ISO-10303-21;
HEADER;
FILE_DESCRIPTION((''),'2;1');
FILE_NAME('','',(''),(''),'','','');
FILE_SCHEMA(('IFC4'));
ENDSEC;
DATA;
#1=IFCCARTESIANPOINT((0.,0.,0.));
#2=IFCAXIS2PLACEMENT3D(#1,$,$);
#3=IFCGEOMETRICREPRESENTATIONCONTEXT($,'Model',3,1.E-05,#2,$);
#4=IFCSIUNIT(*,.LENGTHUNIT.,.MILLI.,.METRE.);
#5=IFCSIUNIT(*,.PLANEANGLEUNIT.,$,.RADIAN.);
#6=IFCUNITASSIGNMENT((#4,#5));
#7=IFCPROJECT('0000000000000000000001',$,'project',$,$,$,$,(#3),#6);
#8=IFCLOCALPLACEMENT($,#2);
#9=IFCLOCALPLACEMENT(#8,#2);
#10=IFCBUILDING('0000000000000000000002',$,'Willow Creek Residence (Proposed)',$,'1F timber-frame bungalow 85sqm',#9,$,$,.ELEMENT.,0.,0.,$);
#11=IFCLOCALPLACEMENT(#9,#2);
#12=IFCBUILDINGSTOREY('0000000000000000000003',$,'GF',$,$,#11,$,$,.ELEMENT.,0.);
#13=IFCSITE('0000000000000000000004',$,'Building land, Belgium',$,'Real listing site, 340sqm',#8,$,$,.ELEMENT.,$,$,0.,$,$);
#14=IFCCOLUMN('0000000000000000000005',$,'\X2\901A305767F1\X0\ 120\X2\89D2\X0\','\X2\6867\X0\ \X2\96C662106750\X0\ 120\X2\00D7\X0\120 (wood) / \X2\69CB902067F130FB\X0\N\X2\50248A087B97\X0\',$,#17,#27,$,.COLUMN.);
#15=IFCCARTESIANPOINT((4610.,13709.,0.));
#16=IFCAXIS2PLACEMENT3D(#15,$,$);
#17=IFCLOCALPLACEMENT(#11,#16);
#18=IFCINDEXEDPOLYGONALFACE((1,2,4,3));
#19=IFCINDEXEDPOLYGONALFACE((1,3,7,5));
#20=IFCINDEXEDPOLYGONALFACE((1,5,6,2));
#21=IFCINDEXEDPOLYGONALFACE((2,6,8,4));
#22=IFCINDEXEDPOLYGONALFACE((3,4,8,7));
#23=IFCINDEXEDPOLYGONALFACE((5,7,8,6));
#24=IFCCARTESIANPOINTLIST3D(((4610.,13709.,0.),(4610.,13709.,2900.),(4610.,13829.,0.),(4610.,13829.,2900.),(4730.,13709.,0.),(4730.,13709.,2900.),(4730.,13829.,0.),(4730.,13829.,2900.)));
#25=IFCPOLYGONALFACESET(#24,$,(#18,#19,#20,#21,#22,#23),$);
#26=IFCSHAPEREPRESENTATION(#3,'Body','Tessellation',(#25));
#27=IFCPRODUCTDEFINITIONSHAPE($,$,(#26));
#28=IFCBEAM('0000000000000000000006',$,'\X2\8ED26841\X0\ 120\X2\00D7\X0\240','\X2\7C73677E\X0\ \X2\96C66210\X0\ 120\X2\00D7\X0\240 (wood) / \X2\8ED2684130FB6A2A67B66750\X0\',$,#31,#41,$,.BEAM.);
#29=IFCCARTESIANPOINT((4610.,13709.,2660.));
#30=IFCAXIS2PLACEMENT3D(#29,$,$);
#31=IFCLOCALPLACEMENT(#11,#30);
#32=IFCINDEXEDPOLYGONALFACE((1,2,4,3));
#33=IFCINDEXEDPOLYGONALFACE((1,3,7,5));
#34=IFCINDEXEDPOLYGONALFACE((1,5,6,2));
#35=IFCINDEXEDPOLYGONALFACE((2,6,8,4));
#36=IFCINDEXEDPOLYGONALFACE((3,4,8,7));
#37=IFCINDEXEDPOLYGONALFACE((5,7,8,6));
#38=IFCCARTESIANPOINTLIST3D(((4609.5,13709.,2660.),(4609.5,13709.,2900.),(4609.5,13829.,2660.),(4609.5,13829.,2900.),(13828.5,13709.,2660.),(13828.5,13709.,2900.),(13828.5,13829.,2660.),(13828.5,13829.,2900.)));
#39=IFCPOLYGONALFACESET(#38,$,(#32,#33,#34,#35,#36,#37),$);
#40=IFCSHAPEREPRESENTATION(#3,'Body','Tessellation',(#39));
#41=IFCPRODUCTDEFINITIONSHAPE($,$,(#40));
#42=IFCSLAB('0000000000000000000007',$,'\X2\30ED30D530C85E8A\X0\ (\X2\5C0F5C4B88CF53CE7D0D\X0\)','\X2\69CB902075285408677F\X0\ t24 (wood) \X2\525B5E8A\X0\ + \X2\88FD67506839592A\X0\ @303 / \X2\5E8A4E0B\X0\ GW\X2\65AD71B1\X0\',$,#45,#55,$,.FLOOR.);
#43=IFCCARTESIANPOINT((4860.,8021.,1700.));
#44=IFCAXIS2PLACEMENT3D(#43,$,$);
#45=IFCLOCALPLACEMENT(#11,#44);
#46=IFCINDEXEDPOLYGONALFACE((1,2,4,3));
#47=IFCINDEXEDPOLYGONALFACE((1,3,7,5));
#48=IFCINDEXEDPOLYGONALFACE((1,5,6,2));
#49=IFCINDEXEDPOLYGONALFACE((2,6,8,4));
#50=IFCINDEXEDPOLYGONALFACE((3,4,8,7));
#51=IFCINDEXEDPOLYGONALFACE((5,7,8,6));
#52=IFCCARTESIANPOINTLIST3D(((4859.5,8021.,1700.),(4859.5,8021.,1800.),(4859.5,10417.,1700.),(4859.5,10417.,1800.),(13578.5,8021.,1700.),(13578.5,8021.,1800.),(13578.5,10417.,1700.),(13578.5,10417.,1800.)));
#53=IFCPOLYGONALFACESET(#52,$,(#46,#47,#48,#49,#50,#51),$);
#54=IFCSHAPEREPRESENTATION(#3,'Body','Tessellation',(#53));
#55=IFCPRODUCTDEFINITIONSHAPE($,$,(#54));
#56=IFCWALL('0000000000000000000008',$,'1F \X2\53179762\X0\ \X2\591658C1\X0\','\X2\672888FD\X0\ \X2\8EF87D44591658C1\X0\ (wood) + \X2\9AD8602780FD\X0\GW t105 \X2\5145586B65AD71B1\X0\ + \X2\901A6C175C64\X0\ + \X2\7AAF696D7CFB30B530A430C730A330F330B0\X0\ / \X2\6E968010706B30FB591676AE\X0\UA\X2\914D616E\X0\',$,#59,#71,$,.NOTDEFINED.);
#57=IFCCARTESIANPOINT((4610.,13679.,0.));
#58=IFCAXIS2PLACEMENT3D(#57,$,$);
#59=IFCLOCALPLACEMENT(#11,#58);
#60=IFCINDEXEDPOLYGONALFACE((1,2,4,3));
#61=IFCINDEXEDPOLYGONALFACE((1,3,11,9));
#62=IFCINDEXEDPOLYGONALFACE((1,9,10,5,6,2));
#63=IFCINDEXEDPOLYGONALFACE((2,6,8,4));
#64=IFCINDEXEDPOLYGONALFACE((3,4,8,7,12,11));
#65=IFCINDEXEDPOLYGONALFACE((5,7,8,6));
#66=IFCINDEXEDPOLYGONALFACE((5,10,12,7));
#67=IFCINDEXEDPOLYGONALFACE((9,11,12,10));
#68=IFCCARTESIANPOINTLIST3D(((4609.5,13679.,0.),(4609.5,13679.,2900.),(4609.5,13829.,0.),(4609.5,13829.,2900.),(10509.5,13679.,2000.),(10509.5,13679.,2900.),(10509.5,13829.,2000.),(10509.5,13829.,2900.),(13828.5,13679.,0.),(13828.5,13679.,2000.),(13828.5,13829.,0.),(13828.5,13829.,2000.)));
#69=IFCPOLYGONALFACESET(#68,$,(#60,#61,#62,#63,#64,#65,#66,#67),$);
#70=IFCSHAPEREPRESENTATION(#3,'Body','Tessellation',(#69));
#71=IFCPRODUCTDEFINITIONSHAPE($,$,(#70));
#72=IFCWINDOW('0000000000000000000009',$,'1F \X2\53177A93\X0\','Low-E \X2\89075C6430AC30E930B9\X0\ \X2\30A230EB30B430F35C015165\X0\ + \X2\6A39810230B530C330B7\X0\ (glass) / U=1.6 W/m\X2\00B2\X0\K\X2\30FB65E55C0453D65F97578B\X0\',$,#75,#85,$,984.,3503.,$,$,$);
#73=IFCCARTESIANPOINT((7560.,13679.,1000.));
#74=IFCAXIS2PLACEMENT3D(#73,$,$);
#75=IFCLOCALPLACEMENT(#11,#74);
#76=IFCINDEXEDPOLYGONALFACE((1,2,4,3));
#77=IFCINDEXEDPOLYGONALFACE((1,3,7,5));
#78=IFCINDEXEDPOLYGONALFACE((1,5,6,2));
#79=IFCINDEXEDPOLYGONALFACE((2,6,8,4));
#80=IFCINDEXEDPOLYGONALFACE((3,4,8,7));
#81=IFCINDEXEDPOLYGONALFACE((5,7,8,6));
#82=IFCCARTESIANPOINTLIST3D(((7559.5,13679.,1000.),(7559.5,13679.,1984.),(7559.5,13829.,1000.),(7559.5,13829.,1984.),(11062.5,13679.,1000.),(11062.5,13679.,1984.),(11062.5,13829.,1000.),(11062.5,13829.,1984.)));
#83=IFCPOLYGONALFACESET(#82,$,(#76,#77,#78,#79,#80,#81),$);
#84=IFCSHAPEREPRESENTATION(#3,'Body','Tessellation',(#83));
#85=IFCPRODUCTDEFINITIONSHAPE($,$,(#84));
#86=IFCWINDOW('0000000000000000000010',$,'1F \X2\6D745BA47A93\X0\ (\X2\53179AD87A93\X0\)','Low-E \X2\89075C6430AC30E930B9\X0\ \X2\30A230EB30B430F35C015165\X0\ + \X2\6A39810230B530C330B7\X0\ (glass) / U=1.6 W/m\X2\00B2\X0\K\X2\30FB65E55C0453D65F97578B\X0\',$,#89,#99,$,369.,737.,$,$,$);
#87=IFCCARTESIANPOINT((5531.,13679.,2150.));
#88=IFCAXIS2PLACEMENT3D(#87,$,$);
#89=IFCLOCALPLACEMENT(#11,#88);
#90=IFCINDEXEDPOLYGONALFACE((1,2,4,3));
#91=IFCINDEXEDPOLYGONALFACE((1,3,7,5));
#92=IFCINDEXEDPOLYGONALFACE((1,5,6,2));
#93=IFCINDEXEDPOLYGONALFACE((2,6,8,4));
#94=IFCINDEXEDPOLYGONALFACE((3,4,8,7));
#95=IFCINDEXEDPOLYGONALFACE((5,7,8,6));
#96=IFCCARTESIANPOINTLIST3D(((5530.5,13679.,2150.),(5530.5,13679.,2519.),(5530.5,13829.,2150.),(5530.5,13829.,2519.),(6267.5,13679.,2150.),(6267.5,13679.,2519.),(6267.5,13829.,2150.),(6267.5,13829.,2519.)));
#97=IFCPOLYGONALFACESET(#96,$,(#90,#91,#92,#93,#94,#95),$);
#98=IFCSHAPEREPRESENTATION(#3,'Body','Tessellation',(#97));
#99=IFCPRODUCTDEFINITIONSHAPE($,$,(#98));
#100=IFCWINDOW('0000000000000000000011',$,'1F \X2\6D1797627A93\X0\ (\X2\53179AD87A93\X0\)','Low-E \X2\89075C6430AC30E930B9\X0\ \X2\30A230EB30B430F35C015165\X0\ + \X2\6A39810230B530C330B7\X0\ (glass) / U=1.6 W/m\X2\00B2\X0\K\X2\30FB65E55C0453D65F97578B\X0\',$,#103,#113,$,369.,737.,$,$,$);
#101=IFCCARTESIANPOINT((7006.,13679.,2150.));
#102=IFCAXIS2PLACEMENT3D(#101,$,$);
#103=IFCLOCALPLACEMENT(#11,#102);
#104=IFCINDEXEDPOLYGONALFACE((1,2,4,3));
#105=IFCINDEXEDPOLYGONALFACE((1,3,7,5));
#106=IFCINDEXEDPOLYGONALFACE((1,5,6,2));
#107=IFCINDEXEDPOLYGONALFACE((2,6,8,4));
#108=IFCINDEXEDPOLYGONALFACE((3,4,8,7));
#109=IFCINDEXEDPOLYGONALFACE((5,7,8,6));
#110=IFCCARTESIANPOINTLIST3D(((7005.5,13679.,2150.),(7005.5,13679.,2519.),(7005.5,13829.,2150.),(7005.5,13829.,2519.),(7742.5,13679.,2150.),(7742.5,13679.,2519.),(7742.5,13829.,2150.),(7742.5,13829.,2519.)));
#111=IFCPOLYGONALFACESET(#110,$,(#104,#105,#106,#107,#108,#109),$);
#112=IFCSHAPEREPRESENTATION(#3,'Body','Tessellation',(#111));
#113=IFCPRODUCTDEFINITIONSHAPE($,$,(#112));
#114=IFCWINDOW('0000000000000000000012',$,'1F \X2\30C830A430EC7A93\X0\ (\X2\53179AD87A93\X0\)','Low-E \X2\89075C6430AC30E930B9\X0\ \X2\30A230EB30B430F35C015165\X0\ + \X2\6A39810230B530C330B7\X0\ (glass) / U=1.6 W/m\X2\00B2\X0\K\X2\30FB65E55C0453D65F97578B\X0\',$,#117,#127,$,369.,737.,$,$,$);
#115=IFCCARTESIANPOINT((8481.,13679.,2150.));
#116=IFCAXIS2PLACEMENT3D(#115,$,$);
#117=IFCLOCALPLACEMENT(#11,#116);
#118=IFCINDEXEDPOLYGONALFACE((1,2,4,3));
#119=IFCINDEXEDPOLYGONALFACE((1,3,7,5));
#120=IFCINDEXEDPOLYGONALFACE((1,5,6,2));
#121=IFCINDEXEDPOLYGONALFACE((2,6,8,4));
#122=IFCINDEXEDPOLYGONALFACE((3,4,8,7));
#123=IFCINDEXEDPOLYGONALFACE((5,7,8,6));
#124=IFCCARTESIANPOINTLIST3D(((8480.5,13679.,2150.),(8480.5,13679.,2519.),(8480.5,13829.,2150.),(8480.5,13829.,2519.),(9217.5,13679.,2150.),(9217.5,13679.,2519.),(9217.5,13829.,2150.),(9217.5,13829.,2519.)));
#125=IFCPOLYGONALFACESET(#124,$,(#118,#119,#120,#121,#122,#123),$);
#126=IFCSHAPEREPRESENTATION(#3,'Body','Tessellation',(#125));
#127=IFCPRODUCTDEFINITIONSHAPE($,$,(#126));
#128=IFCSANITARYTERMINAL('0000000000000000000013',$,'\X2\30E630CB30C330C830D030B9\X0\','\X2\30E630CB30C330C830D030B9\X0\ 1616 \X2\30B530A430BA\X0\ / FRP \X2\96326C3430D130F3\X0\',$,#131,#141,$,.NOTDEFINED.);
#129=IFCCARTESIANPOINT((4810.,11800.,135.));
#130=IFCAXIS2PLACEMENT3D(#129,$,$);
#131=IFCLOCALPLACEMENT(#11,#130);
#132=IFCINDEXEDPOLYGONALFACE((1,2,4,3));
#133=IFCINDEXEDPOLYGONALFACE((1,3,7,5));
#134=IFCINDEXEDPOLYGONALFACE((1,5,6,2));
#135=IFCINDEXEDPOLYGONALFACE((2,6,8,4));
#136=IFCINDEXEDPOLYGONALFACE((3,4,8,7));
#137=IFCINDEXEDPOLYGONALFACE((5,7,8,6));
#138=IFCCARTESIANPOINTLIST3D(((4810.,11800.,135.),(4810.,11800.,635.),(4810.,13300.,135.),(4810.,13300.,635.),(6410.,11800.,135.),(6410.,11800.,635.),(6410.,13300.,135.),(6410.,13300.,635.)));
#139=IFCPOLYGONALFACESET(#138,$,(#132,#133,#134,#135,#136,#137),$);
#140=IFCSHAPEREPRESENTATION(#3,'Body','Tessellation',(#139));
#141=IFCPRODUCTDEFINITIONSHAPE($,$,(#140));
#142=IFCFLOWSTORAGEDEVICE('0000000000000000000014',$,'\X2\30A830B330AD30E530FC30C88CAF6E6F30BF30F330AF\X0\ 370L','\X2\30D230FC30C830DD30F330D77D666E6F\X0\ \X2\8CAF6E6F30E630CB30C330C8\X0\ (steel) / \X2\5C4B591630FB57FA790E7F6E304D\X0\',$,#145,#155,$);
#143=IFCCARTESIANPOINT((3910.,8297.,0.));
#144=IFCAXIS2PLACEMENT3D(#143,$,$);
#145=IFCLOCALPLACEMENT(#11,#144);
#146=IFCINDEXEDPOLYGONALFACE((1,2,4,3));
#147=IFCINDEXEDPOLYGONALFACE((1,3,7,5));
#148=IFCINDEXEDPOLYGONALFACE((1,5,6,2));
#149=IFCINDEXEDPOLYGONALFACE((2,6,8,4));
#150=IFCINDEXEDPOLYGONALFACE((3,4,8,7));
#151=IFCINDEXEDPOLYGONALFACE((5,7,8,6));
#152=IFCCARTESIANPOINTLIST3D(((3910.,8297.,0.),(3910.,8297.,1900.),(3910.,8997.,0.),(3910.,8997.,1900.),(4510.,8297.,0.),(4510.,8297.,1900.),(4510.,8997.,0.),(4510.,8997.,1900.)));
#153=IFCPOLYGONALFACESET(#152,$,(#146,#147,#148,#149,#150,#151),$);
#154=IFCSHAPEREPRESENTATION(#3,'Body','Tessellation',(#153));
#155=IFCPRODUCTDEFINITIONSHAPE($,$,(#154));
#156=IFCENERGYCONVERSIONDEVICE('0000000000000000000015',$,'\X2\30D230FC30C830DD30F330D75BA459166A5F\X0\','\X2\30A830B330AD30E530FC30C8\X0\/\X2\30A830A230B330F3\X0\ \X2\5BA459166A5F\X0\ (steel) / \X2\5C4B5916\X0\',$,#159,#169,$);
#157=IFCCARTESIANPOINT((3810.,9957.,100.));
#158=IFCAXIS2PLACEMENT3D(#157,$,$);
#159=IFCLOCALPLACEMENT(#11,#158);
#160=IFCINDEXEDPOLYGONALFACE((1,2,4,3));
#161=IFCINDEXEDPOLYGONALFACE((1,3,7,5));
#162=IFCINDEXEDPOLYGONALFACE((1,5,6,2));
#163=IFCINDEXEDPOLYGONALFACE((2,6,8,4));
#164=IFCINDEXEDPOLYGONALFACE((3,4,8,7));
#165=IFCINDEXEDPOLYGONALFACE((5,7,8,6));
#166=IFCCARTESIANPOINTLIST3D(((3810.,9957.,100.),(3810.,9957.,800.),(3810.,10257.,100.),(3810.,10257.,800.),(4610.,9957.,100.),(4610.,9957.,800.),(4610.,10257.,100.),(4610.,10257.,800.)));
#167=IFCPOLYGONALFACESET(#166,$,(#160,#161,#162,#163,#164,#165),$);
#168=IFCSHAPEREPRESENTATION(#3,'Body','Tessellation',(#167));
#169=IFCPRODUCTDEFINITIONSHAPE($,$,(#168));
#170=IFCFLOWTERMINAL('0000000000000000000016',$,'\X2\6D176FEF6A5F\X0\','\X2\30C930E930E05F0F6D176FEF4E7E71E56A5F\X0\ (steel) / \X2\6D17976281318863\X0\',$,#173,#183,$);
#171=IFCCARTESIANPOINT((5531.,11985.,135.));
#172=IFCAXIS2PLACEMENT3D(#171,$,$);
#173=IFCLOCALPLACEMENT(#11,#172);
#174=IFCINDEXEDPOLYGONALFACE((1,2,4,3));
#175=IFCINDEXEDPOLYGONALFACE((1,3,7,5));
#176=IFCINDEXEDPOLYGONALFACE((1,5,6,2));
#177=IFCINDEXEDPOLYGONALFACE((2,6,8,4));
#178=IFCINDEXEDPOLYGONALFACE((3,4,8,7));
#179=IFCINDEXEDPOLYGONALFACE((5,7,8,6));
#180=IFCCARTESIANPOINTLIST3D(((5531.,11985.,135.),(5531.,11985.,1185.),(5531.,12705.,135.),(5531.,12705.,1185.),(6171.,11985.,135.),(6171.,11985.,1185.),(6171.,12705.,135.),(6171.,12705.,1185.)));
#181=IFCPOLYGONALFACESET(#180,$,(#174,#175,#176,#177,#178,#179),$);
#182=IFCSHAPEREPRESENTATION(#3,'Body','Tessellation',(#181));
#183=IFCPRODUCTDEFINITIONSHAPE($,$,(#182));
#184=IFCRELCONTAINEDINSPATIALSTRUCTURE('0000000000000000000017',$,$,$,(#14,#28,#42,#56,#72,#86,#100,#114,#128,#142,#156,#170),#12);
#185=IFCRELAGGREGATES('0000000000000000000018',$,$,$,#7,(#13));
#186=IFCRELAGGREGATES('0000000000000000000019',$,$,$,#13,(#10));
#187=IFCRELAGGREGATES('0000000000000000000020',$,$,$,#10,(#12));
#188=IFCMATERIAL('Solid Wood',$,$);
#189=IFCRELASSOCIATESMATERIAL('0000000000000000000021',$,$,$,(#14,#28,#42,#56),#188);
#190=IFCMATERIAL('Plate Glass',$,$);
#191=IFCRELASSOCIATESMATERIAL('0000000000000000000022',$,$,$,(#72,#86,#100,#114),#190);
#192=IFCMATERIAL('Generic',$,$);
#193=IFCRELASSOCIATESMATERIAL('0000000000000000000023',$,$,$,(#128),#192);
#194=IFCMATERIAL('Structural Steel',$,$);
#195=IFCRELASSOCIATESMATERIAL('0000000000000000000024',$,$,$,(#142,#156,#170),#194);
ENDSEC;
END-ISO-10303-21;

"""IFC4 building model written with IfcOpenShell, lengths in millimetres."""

from ifc_helpers import new_model, si_unit, frame, frame_2d, origin, place, context, project, spatial, rectangle, extrude, material, element, fill, save


model = new_model("IFC4")

# Units and contexts
model_context = context("Model", 3, precision=1e-05, world=origin())
ifc_project = project(units=[si_unit("LENGTHUNIT", "METRE", prefix="MILLI"), si_unit("PLANEANGLEUNIT", "RADIAN")], contexts=[model_context])

# Site, building, storey
site_placement = place(None, origin())
site = spatial("IfcSite", under=ifc_project, at=site_placement, Name="Building land, Belgium", ObjectType="Real listing site, 340sqm", CompositionType="ELEMENT", RefElevation=0.0)
building_placement = place(site_placement, origin())
building = spatial("IfcBuilding", under=site, at=building_placement, Name="Willow Creek Residence (Proposed)", ObjectType="1F timber-frame bungalow 85sqm", CompositionType="ELEMENT", ElevationOfRefHeight=0.0, ElevationOfTerrain=0.0)
storey_placement = place(building_placement, origin())
storey = spatial("IfcBuildingStorey", under=building, at=storey_placement, Name="GF", CompositionType="ELEMENT", Elevation=0.0)

# Column
ifc_material_1 = material(Name="Solid Wood")
column_1_placement = place(storey_placement, frame((4610.0, 13709.0, 0.0)))
element("IfcColumn", 1, at=column_1_placement, inside=storey, material=ifc_material_1, Name="通し柱 120角", Description="桧 集成材 120×120 (wood) / 構造柱・N値計算", PredefinedType="COLUMN", context=model_context, shape_type="SweptSolid", body=[
    extrude(rectangle(XDim=120.0, YDim=120.0, at=frame_2d((60.0, 60.0))), frame((4610.0, 13709.0, 0.0)), (0.0, 0.0, 1.0), 2900.0),
])

# Beam
beam_1_placement = place(storey_placement, frame((4610.0, 13709.0, 2660.0)))
element("IfcBeam", 2, at=beam_1_placement, inside=storey, material=ifc_material_1, Name="軒桁 120×240", Description="米松 集成 120×240 (wood) / 軒桁・横架材", PredefinedType="BEAM", context=model_context, shape_type="SweptSolid", body=[
    extrude(rectangle(XDim=9219.0, YDim=120.0, at=frame_2d((4609.0, 60.0))), frame((4610.0, 13709.0, 2660.0)), (0.0, 0.0, 1.0), 240.0),
])

# Slab
slab_placement = place(storey_placement, frame((4860.0, 8021.0, 1700.0)))
element("IfcSlab", 3, at=slab_placement, inside=storey, material=ifc_material_1, Name="ロフト床 (小屋裏収納)", Description="構造用合板 t24 (wood) 剛床 + 製材根太 @303 / 床下 GW断熱", PredefinedType="FLOOR", context=model_context, shape_type="SweptSolid", body=[
    extrude(rectangle(XDim=8719.0, YDim=2396.0, at=frame_2d((4359.0, 1198.0))), frame((4860.0, 8021.0, 1700.0)), (0.0, 0.0, 1.0), 100.0),
])

# Wall, openings, windows
wall_1_placement = place(storey_placement, frame((4610.0, 13679.0, 0.0)))
wall_1 = element("IfcWall", 4, at=wall_1_placement, inside=storey, material=ifc_material_1, Name="1F 北面 外壁", Description="木製 軸組外壁 (wood) + 高性能GW t105 充填断熱 + 通気層 + 窯業系サイディング / 準耐火・外皮UA配慮", PredefinedType="NOTDEFINED", context=model_context, shape_type="SweptSolid", body=[
    extrude(rectangle(XDim=9219.0, YDim=150.0, at=frame_2d((4609.0, 75.0))), frame((4610.0, 13679.0, 0.0)), (0.0, 0.0, 1.0), 2900.0),
])
opening_1_placement = place(storey_placement, frame((7560.0, 13679.0, 1000.0)))
opening_1 = element("IfcOpeningElement", 5, at=opening_1_placement, cuts=wall_1, PredefinedType="NOTDEFINED", context=model_context, shape_type="SweptSolid", body=[
    extrude(rectangle(XDim=3503.0, YDim=150.0, at=frame_2d((1751.0, 75.0))), frame((7560.0, 13679.0, 1000.0)), (0.0, 0.0, 1.0), 984.0),
])
opening_2_placement = place(storey_placement, frame((5531.0, 13679.0, 2150.0)))
opening_2 = element("IfcOpeningElement", 6, at=opening_2_placement, cuts=wall_1, PredefinedType="NOTDEFINED", context=model_context, shape_type="SweptSolid", body=[
    extrude(rectangle(XDim=737.0, YDim=150.0, at=frame_2d((368.0, 75.0))), frame((5531.0, 13679.0, 2150.0)), (0.0, 0.0, 1.0), 369.0),
])
opening_3_placement = place(storey_placement, frame((7006.0, 13679.0, 2150.0)))
opening_3 = element("IfcOpeningElement", 7, at=opening_3_placement, cuts=wall_1, PredefinedType="NOTDEFINED", context=model_context, shape_type="SweptSolid", body=[
    extrude(rectangle(XDim=737.0, YDim=150.0, at=frame_2d((368.0, 75.0))), frame((7006.0, 13679.0, 2150.0)), (0.0, 0.0, 1.0), 369.0),
])
opening_4_placement = place(storey_placement, frame((8481.0, 13679.0, 2150.0)))
opening_4 = element("IfcOpeningElement", 8, at=opening_4_placement, cuts=wall_1, PredefinedType="NOTDEFINED", context=model_context, shape_type="SweptSolid", body=[
    extrude(rectangle(XDim=737.0, YDim=150.0, at=frame_2d((368.0, 75.0))), frame((8481.0, 13679.0, 2150.0)), (0.0, 0.0, 1.0), 369.0),
])
ifc_material_2 = material(Name="Plate Glass")
window_1_placement = place(storey_placement, frame((7560.0, 13679.0, 1000.0)))
window_1 = element("IfcWindow", 9, at=window_1_placement, inside=storey, material=ifc_material_2, Name="1F 北窓", Description="Low-E 複層ガラス アルゴン封入 + 樹脂サッシ (glass) / U=1.6 W/m²K・日射取得型", OverallHeight=984.0, OverallWidth=3503.0, context=model_context, shape_type="SweptSolid", body=[
    extrude(rectangle(XDim=3503.0, YDim=150.0, at=frame_2d((1751.0, 75.0))), frame((7560.0, 13679.0, 1000.0)), (0.0, 0.0, 1.0), 984.0),
])
fill(opening_1, window_1)
window_2_placement = place(storey_placement, frame((5531.0, 13679.0, 2150.0)))
window_2 = element("IfcWindow", 10, at=window_2_placement, inside=storey, material=ifc_material_2, Name="1F 浴室窓 (北高窓)", Description="Low-E 複層ガラス アルゴン封入 + 樹脂サッシ (glass) / U=1.6 W/m²K・日射取得型", OverallHeight=369.0, OverallWidth=737.0, context=model_context, shape_type="SweptSolid", body=[
    extrude(rectangle(XDim=737.0, YDim=150.0, at=frame_2d((368.0, 75.0))), frame((5531.0, 13679.0, 2150.0)), (0.0, 0.0, 1.0), 369.0),
])
fill(opening_2, window_2)
window_3_placement = place(storey_placement, frame((7006.0, 13679.0, 2150.0)))
window_3 = element("IfcWindow", 11, at=window_3_placement, inside=storey, material=ifc_material_2, Name="1F 洗面窓 (北高窓)", Description="Low-E 複層ガラス アルゴン封入 + 樹脂サッシ (glass) / U=1.6 W/m²K・日射取得型", OverallHeight=369.0, OverallWidth=737.0, context=model_context, shape_type="SweptSolid", body=[
    extrude(rectangle(XDim=737.0, YDim=150.0, at=frame_2d((368.0, 75.0))), frame((7006.0, 13679.0, 2150.0)), (0.0, 0.0, 1.0), 369.0),
])
fill(opening_3, window_3)
window_4_placement = place(storey_placement, frame((8481.0, 13679.0, 2150.0)))
window_4 = element("IfcWindow", 12, at=window_4_placement, inside=storey, material=ifc_material_2, Name="1F トイレ窓 (北高窓)", Description="Low-E 複層ガラス アルゴン封入 + 樹脂サッシ (glass) / U=1.6 W/m²K・日射取得型", OverallHeight=369.0, OverallWidth=737.0, context=model_context, shape_type="SweptSolid", body=[
    extrude(rectangle(XDim=737.0, YDim=150.0, at=frame_2d((368.0, 75.0))), frame((8481.0, 13679.0, 2150.0)), (0.0, 0.0, 1.0), 369.0),
])
fill(opening_4, window_4)

# Sanitary terminal
ifc_material_3 = material(Name="Generic")
sanitary_terminal_placement = place(storey_placement, frame((4810.0, 11800.0, 135.0)))
element("IfcSanitaryTerminal", 13, at=sanitary_terminal_placement, inside=storey, material=ifc_material_3, Name="ユニットバス", Description="ユニットバス 1616 サイズ / FRP 防水パン", PredefinedType="NOTDEFINED", context=model_context, shape_type="SweptSolid", body=[
    extrude(rectangle(XDim=1600.0, YDim=1500.0, at=frame_2d((800.0, 750.0))), frame((4810.0, 11800.0, 135.0)), (0.0, 0.0, 1.0), 500.0),
])

# Flow storage device
ifc_material_4 = material(Name="Structural Steel")
flow_storage_device_placement = place(storey_placement, frame((3910.0, 8297.0, 0.0)))
element("IfcFlowStorageDevice", 14, at=flow_storage_device_placement, inside=storey, material=ifc_material_4, Name="エコキュート貯湯タンク 370L", Description="ヒートポンプ給湯 貯湯ユニット (steel) / 屋外・基礎置き", context=model_context, shape_type="SweptSolid", body=[
    extrude(rectangle(XDim=600.0, YDim=700.0, at=frame_2d((300.0, 350.0))), frame((3910.0, 8297.0, 0.0)), (0.0, 0.0, 1.0), 1900.0),
])

# Energy conversion device
energy_conversion_device_placement = place(storey_placement, frame((3810.0, 9957.0, 100.0)))
element("IfcEnergyConversionDevice", 15, at=energy_conversion_device_placement, inside=storey, material=ifc_material_4, Name="ヒートポンプ室外機", Description="エコキュート/エアコン 室外機 (steel) / 屋外", context=model_context, shape_type="SweptSolid", body=[
    extrude(rectangle(XDim=800.0, YDim=300.0, at=frame_2d((400.0, 150.0))), frame((3810.0, 9957.0, 100.0)), (0.0, 0.0, 1.0), 700.0),
])

# Flow terminal
flow_terminal_placement = place(storey_placement, frame((5531.0, 11985.0, 135.0)))
element("IfcFlowTerminal", 16, at=flow_terminal_placement, inside=storey, material=ifc_material_4, Name="洗濯機", Description="ドラム式洗濯乾燥機 (steel) / 洗面脱衣", context=model_context, shape_type="SweptSolid", body=[
    extrude(rectangle(XDim=640.0, YDim=720.0, at=frame_2d((320.0, 360.0))), frame((5531.0, 11985.0, 135.0)), (0.0, 0.0, 1.0), 1050.0),
])

save(model, "model.ifc")
